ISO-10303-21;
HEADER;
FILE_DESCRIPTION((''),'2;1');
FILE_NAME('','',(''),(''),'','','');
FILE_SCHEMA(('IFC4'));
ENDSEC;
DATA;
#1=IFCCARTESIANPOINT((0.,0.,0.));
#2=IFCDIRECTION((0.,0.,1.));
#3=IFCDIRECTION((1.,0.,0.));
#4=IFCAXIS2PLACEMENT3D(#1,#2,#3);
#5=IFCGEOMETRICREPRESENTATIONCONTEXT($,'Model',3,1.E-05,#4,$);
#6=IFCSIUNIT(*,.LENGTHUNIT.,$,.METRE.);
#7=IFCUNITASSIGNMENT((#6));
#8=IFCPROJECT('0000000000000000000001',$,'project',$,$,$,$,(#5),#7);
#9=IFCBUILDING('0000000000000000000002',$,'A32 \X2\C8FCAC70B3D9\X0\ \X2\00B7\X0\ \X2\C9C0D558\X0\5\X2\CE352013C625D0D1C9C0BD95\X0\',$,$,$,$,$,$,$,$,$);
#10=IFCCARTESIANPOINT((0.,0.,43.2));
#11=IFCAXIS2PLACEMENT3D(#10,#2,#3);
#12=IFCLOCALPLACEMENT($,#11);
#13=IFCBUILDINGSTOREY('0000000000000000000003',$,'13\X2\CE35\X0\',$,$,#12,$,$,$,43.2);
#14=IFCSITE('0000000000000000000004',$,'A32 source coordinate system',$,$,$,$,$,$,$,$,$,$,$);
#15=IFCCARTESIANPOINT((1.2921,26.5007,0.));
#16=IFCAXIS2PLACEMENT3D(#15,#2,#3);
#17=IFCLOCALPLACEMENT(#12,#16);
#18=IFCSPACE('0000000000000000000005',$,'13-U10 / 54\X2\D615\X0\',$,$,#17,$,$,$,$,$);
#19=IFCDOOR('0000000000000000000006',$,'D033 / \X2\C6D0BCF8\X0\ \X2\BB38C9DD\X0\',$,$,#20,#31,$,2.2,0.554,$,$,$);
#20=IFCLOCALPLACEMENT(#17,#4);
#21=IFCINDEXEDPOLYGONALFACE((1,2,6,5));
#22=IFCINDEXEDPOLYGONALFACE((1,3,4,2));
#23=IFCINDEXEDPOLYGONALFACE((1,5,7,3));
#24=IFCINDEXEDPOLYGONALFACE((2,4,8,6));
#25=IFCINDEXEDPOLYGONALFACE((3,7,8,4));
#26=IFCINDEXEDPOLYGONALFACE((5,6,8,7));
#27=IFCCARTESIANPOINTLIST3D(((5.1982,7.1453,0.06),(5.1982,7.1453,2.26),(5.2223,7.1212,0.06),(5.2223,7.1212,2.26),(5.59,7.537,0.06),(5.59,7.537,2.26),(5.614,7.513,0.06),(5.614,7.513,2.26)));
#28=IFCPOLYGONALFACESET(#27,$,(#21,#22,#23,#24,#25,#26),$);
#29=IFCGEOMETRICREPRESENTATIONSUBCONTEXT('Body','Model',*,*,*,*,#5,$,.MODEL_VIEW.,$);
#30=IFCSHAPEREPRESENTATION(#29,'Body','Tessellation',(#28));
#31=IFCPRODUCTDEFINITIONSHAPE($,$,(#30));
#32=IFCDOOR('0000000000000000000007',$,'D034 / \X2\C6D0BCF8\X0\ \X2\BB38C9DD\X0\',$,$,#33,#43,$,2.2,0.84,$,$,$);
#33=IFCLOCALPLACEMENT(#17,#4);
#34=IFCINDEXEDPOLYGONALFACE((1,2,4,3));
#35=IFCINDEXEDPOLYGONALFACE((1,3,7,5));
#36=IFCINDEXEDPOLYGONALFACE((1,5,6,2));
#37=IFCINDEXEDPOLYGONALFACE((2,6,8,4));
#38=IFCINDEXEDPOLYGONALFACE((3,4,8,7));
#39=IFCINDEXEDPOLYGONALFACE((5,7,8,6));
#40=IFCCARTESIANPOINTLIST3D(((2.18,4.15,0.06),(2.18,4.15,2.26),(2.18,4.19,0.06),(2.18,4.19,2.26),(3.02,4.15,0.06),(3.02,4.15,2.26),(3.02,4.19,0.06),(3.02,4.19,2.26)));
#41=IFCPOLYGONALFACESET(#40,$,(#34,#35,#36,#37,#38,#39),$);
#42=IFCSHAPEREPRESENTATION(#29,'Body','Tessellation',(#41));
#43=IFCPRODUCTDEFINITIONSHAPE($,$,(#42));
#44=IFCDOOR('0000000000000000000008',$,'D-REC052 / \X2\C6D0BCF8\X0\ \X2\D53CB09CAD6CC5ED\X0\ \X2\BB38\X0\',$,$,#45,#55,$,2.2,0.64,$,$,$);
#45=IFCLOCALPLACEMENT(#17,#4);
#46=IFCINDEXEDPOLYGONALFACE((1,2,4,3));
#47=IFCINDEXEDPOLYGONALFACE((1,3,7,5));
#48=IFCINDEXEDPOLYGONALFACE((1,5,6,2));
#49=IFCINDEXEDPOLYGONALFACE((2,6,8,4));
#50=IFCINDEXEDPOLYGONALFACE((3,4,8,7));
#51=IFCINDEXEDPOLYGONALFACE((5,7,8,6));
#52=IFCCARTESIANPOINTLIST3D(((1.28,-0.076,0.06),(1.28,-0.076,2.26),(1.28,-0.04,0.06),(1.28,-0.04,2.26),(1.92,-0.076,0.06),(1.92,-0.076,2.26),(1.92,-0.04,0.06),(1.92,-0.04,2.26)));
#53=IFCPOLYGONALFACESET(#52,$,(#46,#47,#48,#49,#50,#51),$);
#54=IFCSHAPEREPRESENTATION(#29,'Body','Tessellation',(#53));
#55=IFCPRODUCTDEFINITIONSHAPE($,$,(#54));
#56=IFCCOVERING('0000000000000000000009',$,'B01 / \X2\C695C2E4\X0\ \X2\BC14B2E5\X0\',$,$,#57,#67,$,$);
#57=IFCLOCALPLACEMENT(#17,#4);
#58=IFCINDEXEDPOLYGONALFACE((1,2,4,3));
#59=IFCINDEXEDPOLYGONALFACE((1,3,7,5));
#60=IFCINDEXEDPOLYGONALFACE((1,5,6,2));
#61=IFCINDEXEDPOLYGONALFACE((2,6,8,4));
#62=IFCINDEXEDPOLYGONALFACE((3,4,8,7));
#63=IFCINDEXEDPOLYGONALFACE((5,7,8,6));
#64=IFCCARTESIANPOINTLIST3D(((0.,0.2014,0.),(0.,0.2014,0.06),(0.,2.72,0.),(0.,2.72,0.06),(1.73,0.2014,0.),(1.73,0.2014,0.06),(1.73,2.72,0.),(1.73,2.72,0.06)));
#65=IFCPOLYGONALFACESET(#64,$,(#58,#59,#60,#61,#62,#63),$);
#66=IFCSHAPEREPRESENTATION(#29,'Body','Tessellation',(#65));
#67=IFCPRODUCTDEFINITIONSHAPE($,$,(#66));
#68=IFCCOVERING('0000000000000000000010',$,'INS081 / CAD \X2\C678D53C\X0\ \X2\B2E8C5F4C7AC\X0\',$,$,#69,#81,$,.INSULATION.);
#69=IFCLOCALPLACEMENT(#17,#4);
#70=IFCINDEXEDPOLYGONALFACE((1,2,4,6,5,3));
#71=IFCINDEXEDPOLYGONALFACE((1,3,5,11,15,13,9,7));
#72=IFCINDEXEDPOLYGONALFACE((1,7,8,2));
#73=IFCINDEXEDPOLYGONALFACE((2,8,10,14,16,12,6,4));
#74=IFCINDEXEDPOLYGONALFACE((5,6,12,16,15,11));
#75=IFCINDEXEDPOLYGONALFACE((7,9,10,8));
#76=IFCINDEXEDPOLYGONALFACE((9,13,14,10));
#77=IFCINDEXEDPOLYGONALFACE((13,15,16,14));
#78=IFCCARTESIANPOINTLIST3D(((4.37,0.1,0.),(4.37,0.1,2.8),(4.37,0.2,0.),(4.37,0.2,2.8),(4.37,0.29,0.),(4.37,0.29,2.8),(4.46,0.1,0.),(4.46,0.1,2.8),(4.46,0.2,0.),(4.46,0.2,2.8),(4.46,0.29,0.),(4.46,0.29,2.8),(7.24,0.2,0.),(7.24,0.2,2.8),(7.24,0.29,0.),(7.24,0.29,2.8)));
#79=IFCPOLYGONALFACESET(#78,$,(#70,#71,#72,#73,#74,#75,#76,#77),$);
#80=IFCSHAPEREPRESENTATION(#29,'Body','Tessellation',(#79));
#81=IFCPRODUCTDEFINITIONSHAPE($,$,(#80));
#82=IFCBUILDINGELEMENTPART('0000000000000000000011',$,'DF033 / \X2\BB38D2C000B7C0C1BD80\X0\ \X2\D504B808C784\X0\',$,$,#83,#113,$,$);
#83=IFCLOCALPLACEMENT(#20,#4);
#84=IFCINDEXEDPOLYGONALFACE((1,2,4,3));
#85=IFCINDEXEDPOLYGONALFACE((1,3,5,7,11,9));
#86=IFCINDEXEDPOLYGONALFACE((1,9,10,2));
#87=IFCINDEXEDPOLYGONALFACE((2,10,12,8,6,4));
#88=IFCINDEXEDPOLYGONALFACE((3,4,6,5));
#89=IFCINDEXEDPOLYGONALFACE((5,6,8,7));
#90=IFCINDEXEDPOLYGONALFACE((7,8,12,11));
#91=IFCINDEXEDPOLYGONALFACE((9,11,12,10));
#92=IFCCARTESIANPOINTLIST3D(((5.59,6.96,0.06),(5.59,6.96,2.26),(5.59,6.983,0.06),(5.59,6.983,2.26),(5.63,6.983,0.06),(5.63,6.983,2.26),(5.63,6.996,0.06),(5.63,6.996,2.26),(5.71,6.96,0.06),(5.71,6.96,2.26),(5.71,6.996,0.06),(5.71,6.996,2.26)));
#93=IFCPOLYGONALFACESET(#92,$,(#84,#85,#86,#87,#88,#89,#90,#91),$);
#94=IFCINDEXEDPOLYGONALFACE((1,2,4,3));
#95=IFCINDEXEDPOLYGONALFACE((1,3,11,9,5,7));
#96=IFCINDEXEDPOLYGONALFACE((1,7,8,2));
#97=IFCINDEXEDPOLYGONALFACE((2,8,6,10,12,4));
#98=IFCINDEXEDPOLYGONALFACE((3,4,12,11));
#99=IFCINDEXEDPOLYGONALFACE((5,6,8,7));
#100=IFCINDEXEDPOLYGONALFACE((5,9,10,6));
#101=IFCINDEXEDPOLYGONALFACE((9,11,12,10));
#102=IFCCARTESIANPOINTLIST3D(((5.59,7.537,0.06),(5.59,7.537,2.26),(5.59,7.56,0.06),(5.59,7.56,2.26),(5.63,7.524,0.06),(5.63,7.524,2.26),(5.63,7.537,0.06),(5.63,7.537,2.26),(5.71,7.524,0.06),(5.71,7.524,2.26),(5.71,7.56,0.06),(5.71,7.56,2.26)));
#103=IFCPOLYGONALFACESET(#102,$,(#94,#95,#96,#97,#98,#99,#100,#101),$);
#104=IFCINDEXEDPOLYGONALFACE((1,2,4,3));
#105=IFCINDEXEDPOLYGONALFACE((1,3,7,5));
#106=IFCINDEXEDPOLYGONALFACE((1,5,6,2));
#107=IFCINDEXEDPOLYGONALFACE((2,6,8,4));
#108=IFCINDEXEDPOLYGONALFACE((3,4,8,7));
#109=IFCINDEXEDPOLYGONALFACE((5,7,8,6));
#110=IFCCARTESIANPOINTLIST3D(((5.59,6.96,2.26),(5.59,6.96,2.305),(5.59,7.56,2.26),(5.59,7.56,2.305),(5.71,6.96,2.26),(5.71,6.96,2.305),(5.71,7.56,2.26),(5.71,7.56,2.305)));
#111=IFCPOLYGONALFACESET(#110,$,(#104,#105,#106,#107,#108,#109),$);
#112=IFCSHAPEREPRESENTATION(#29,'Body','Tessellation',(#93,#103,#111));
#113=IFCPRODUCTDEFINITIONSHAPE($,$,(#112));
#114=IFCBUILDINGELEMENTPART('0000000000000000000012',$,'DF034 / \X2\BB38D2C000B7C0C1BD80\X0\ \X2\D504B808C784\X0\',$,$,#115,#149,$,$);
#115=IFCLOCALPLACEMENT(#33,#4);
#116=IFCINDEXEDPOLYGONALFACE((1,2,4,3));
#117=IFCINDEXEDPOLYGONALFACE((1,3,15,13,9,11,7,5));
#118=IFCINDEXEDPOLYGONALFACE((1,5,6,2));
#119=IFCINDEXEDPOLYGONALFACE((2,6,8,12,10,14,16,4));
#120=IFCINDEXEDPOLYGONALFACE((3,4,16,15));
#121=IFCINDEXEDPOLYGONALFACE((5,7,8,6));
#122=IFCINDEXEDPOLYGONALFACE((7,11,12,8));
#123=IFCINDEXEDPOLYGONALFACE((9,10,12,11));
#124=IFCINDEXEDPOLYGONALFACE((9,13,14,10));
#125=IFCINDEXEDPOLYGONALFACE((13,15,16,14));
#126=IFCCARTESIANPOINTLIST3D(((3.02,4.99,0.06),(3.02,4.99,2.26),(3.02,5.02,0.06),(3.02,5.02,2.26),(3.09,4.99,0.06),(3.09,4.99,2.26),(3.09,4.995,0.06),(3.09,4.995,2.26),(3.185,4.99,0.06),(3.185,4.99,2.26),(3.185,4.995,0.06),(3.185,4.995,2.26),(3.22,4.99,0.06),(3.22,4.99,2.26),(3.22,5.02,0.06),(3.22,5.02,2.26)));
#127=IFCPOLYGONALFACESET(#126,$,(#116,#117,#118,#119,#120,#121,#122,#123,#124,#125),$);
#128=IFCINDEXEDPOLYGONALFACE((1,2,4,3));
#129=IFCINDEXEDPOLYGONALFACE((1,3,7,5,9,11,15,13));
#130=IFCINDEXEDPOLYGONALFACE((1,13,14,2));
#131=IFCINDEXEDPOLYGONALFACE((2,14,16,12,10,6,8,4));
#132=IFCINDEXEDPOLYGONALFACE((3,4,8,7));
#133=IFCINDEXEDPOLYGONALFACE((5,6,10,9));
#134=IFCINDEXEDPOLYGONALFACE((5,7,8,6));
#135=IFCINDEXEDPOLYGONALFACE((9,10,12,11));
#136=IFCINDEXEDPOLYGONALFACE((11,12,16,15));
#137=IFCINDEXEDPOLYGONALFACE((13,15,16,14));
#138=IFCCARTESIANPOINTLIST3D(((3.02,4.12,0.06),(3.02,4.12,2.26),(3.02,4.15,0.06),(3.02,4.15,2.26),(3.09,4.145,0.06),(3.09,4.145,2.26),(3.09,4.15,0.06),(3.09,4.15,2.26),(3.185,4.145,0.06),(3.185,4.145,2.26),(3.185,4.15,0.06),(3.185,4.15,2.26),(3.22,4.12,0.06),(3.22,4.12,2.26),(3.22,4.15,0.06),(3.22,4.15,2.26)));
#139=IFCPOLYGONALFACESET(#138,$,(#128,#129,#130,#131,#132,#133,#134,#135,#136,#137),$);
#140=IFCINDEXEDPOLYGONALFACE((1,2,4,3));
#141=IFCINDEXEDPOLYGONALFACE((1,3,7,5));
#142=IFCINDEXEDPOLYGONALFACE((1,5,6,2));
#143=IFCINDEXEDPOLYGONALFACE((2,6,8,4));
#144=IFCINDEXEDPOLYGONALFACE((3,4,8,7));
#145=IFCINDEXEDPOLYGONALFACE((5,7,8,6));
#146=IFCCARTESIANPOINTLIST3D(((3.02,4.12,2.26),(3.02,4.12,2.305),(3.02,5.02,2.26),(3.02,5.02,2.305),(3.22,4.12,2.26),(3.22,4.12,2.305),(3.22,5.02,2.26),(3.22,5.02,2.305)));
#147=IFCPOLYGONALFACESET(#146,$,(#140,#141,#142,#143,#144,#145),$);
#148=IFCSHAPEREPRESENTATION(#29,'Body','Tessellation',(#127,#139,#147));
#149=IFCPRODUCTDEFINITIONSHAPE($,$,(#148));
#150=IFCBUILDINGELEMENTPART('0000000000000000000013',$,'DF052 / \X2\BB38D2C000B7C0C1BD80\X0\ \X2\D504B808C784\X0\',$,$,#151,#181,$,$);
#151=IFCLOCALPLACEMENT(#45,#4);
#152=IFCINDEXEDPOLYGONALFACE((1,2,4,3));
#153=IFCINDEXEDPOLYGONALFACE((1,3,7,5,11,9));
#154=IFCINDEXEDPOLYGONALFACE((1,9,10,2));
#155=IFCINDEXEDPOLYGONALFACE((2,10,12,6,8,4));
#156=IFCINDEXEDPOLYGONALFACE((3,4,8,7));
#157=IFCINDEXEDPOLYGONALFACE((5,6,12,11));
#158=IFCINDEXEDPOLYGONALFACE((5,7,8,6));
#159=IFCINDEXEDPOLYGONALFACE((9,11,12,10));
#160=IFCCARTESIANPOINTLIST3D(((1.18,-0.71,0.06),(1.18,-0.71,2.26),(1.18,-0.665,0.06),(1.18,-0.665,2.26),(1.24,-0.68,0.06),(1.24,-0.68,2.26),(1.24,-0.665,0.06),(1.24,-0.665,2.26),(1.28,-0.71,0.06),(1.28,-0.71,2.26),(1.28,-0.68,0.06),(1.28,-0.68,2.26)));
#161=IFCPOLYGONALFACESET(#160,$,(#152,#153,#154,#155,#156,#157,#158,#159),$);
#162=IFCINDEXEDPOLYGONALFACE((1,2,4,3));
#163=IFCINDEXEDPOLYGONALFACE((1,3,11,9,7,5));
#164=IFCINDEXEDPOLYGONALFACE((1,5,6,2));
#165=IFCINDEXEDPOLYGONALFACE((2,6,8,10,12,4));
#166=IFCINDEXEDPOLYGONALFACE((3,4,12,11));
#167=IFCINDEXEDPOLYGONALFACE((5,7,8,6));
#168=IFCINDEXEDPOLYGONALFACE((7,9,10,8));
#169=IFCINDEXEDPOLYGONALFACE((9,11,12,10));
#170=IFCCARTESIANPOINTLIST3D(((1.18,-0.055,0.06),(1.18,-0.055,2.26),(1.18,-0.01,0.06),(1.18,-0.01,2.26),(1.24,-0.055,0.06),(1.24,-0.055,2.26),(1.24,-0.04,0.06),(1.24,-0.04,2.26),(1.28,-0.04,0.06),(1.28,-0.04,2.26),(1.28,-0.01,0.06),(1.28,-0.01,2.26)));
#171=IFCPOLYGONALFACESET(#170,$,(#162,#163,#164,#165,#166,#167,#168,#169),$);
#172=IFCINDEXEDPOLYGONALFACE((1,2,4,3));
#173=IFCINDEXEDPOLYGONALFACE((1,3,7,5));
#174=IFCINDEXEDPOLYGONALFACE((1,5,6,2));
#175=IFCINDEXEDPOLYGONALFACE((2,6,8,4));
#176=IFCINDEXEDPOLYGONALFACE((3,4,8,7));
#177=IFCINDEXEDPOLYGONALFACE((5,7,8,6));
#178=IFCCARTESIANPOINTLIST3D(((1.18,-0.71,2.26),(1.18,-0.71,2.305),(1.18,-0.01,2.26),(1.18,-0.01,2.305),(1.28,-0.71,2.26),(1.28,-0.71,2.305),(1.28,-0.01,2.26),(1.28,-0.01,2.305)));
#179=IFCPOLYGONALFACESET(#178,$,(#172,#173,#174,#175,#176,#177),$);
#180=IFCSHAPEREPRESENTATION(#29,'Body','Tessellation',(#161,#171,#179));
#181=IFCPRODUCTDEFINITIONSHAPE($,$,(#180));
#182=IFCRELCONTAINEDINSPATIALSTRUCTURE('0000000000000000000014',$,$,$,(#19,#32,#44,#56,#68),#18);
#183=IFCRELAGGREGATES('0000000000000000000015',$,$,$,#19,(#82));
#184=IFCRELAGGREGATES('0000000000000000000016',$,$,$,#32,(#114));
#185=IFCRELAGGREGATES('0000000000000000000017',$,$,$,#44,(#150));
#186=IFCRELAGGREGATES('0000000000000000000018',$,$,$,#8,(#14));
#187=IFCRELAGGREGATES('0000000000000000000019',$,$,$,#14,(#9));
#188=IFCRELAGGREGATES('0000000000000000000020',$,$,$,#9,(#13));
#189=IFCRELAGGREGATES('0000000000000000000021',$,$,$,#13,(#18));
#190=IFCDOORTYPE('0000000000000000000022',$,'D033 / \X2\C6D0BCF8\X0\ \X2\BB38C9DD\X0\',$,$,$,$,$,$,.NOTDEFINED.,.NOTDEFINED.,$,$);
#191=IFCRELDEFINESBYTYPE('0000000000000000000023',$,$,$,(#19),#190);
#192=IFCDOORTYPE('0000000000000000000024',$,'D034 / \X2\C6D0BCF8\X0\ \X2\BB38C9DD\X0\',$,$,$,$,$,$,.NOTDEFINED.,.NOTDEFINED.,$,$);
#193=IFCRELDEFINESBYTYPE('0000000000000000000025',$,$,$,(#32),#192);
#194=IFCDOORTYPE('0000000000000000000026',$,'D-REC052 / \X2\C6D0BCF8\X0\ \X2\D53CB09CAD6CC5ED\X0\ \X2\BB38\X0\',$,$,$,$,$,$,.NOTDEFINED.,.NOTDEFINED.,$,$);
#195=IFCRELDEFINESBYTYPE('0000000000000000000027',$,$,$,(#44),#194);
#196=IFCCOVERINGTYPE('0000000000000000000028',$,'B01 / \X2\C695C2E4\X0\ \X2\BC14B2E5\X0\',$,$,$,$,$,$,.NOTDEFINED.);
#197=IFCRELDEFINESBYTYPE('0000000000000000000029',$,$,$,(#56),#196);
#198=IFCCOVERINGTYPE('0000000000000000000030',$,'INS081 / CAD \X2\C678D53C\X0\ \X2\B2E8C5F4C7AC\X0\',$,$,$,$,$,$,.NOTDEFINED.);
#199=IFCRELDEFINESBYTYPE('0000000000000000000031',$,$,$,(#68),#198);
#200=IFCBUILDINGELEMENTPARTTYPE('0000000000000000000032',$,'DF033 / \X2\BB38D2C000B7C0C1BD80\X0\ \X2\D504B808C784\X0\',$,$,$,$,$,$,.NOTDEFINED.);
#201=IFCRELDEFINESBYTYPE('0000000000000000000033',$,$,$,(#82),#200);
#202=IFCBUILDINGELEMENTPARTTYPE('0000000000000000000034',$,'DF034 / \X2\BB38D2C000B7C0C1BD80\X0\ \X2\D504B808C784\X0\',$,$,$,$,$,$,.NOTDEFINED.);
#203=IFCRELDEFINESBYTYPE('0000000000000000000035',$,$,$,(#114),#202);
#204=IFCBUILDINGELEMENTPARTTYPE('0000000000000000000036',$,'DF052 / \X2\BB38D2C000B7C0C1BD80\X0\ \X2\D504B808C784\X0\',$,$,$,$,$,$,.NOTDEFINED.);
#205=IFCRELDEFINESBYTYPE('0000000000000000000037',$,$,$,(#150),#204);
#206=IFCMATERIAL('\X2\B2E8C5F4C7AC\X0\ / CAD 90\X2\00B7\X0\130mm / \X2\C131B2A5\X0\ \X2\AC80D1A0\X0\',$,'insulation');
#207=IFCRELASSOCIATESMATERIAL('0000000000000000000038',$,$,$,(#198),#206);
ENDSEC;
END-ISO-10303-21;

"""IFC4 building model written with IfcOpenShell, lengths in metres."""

from ifc_helpers import new_model, si_unit, frame, origin, origin_with_axes, place, context, subcontext, project, spatial, polyline, outline, extrude, source, transform, mapped, material, type_object, type_shapes, element, aggregate, save


model = new_model("IFC4")

# Units and contexts
model_context = context("Model", 3, precision=1e-05, world=origin_with_axes())
body_context = subcontext(model_context, "Body", "Model", "MODEL_VIEW")
ifc_project = project(units=[si_unit("LENGTHUNIT", "METRE")], contexts=[model_context])

# Site, building, storey, space
storey_placement = place(None, frame((0.0, 0.0, 43.2), z_axis=(0.0, 0.0, 1.0), x_axis=(1.0, 0.0, 0.0)))
space_placement = place(storey_placement, frame((1.2921, 26.5007, 0.0), z_axis=(0.0, 0.0, 1.0), x_axis=(1.0, 0.0, 0.0)))
site = spatial("IfcSite", under=ifc_project, Name="A32 source coordinate system")
building = spatial("IfcBuilding", under=site, Name="A32 주거동 · 지하5층–옥탑지붕")
storey = spatial("IfcBuildingStorey", under=building, at=storey_placement, Name="13층", Elevation=43.2)
space = spatial("IfcSpace", under=storey, at=space_placement, Name="13-U10 / 54형")

# Doors
door_type_1 = type_object("IfcDoorType", Name="D033 / 원본 문짝", OperationType="NOTDEFINED", PredefinedType="NOTDEFINED")
shared_shape_1 = source(origin(), body_context, "Body", "SweptSolid", [
    extrude(outline(polyline([(5.2223, 7.1212), (5.1982, 7.1453), (5.59, 7.537), (5.614, 7.513), (5.2223, 7.1212)])), frame((0.0, 0.0, 0.06)), (0.0, 0.0, 1.0), 2.2),
])
type_shapes(door_type_1, [shared_shape_1])
door_1_placement = place(space_placement, origin_with_axes())
door_1 = element("IfcDoor", 1, at=door_1_placement, inside=space, type_object=door_type_1, Name="D033 / 원본 문짝", OverallHeight=2.2, OverallWidth=0.554, context=body_context, shape_type="MappedRepresentation", body=[
    mapped(shared_shape_1, transform((0.0, 0.0, 0.0), scale=1.0)),
])
door_type_2 = type_object("IfcDoorType", Name="D034 / 원본 문짝", OperationType="NOTDEFINED", PredefinedType="NOTDEFINED")
shared_shape_2 = source(origin(), body_context, "Body", "SweptSolid", [
    extrude(outline(polyline([(3.02, 4.15), (2.18, 4.15), (2.18, 4.19), (3.02, 4.19), (3.02, 4.15)])), frame((0.0, 0.0, 0.06)), (0.0, 0.0, 1.0), 2.2),
])
type_shapes(door_type_2, [shared_shape_2])
door_2_placement = place(space_placement, origin_with_axes())
door_2 = element("IfcDoor", 2, at=door_2_placement, inside=space, type_object=door_type_2, Name="D034 / 원본 문짝", OverallHeight=2.2, OverallWidth=0.84, context=body_context, shape_type="MappedRepresentation", body=[
    mapped(shared_shape_2, transform((0.0, 0.0, 0.0), scale=1.0)),
])
door_type_3 = type_object("IfcDoorType", Name="D-REC052 / 원본 피난구역 문", OperationType="NOTDEFINED", PredefinedType="NOTDEFINED")
shared_shape_3 = source(origin(), body_context, "Body", "SweptSolid", [
    extrude(outline(polyline([(1.92, -0.076), (1.28, -0.076), (1.28, -0.04), (1.92, -0.04), (1.92, -0.076)])), frame((0.0, 0.0, 0.06)), (0.0, 0.0, 1.0), 2.2),
])
type_shapes(door_type_3, [shared_shape_3])
door_3_placement = place(space_placement, origin_with_axes())
door_3 = element("IfcDoor", 3, at=door_3_placement, inside=space, type_object=door_type_3, Name="D-REC052 / 원본 피난구역 문", OverallHeight=2.2, OverallWidth=0.64, context=body_context, shape_type="MappedRepresentation", body=[
    mapped(shared_shape_3, transform((0.0, 0.0, 0.0), scale=1.0)),
])

# Coverings
covering_type_1 = type_object("IfcCoveringType", Name="B01 / 욕실 바닥", PredefinedType="NOTDEFINED")
shared_shape_4 = source(origin(), body_context, "Body", "SweptSolid", [
    extrude(outline(polyline([(0.0, 0.2014), (0.0, 2.72), (1.73, 2.72), (1.73, 0.2014), (0.0, 0.2014)])), origin(), (0.0, 0.0, 1.0), 0.06),
])
type_shapes(covering_type_1, [shared_shape_4])
covering_1_placement = place(space_placement, origin_with_axes())
element("IfcCovering", 4, at=covering_1_placement, inside=space, type_object=covering_type_1, Name="B01 / 욕실 바닥", context=body_context, shape_type="MappedRepresentation", body=[
    mapped(shared_shape_4, transform((0.0, 0.0, 0.0), scale=1.0)),
])
ifc_material = material(Name="단열재 / CAD 90·130mm / 성능 검토", Category="insulation")
covering_type_2 = type_object("IfcCoveringType", Name="INS081 / CAD 외피 단열재", PredefinedType="NOTDEFINED", material=ifc_material)
shared_shape_5 = source(origin(), body_context, "Body", "SweptSolid", [
    extrude(outline(polyline([(4.37, 0.2), (4.37, 0.29), (4.46, 0.29), (7.24, 0.29), (7.24, 0.2), (4.46, 0.2), (4.46, 0.1), (4.37, 0.1), (4.37, 0.2)])), origin(), (0.0, 0.0, 1.0), 2.8),
])
type_shapes(covering_type_2, [shared_shape_5])
covering_2_placement = place(space_placement, origin_with_axes())
element("IfcCovering", 5, at=covering_2_placement, inside=space, type_object=covering_type_2, Name="INS081 / CAD 외피 단열재", PredefinedType="INSULATION", context=body_context, shape_type="MappedRepresentation", body=[
    mapped(shared_shape_5, transform((0.0, 0.0, 0.0), scale=1.0)),
])

# Building element parts
building_element_part_type_1 = type_object("IfcBuildingElementPartType", Name="DF033 / 문틀·상부 프레임", PredefinedType="NOTDEFINED")
shared_shape_6 = source(origin(), body_context, "Body", "SweptSolid", [
    extrude(outline(polyline([(5.59, 6.96), (5.59, 6.983), (5.63, 6.983), (5.63, 6.996), (5.71, 6.996), (5.71, 6.96), (5.59, 6.96)])), frame((0.0, 0.0, 0.06)), (0.0, 0.0, 1.0), 2.2),
    extrude(outline(polyline([(5.71, 7.524), (5.63, 7.524), (5.63, 7.537), (5.59, 7.537), (5.59, 7.56), (5.71, 7.56), (5.71, 7.524)])), frame((0.0, 0.0, 0.06)), (0.0, 0.0, 1.0), 2.2),
    extrude(outline(polyline([(5.59, 6.96), (5.59, 7.56), (5.71, 7.56), (5.71, 6.96), (5.59, 6.96)])), frame((0.0, 0.0, 2.26)), (0.0, 0.0, 1.0), 0.045),
])
type_shapes(building_element_part_type_1, [shared_shape_6])
building_element_part_1_placement = place(door_1_placement, origin_with_axes())
building_element_part_1 = element("IfcBuildingElementPart", 6, at=building_element_part_1_placement, type_object=building_element_part_type_1, Name="DF033 / 문틀·상부 프레임", context=body_context, shape_type="MappedRepresentation", body=[
    mapped(shared_shape_6, transform((0.0, 0.0, 0.0), scale=1.0)),
])
aggregate(door_1, [building_element_part_1])
building_element_part_type_2 = type_object("IfcBuildingElementPartType", Name="DF034 / 문틀·상부 프레임", PredefinedType="NOTDEFINED")
shared_shape_7 = source(origin(), body_context, "Body", "SweptSolid", [
    extrude(outline(polyline([(3.22, 5.02), (3.22, 4.99), (3.185, 4.99), (3.185, 4.995), (3.09, 4.995), (3.09, 4.99), (3.02, 4.99), (3.02, 5.02), (3.22, 5.02)])), frame((0.0, 0.0, 0.06)), (0.0, 0.0, 1.0), 2.2),
    extrude(outline(polyline([(3.02, 4.15), (3.09, 4.15), (3.09, 4.145), (3.185, 4.145), (3.185, 4.15), (3.22, 4.15), (3.22, 4.12), (3.02, 4.12), (3.02, 4.15)])), frame((0.0, 0.0, 0.06)), (0.0, 0.0, 1.0), 2.2),
    extrude(outline(polyline([(3.02, 4.12), (3.02, 5.02), (3.22, 5.02), (3.22, 4.12), (3.02, 4.12)])), frame((0.0, 0.0, 2.26)), (0.0, 0.0, 1.0), 0.045),
])
type_shapes(building_element_part_type_2, [shared_shape_7])
building_element_part_2_placement = place(door_2_placement, origin_with_axes())
building_element_part_2 = element("IfcBuildingElementPart", 7, at=building_element_part_2_placement, type_object=building_element_part_type_2, Name="DF034 / 문틀·상부 프레임", context=body_context, shape_type="MappedRepresentation", body=[
    mapped(shared_shape_7, transform((0.0, 0.0, 0.0), scale=1.0)),
])
aggregate(door_2, [building_element_part_2])
building_element_part_type_3 = type_object("IfcBuildingElementPartType", Name="DF052 / 문틀·상부 프레임", PredefinedType="NOTDEFINED")
shared_shape_8 = source(origin(), body_context, "Body", "SweptSolid", [
    extrude(outline(polyline([(1.18, -0.71), (1.18, -0.665), (1.24, -0.665), (1.24, -0.68), (1.28, -0.68), (1.28, -0.71), (1.18, -0.71)])), frame((0.0, 0.0, 0.06)), (0.0, 0.0, 1.0), 2.2),
    extrude(outline(polyline([(1.28, -0.04), (1.24, -0.04), (1.24, -0.055), (1.18, -0.055), (1.18, -0.01), (1.28, -0.01), (1.28, -0.04)])), frame((0.0, 0.0, 0.06)), (0.0, 0.0, 1.0), 2.2),
    extrude(outline(polyline([(1.18, -0.71), (1.18, -0.01), (1.28, -0.01), (1.28, -0.71), (1.18, -0.71)])), frame((0.0, 0.0, 2.26)), (0.0, 0.0, 1.0), 0.045),
])
type_shapes(building_element_part_type_3, [shared_shape_8])
building_element_part_3_placement = place(door_3_placement, origin_with_axes())
building_element_part_3 = element("IfcBuildingElementPart", 8, at=building_element_part_3_placement, type_object=building_element_part_type_3, Name="DF052 / 문틀·상부 프레임", context=body_context, shape_type="MappedRepresentation", body=[
    mapped(shared_shape_8, transform((0.0, 0.0, 0.0), scale=1.0)),
])
aggregate(door_3, [building_element_part_3])

save(model, "model.ifc")
